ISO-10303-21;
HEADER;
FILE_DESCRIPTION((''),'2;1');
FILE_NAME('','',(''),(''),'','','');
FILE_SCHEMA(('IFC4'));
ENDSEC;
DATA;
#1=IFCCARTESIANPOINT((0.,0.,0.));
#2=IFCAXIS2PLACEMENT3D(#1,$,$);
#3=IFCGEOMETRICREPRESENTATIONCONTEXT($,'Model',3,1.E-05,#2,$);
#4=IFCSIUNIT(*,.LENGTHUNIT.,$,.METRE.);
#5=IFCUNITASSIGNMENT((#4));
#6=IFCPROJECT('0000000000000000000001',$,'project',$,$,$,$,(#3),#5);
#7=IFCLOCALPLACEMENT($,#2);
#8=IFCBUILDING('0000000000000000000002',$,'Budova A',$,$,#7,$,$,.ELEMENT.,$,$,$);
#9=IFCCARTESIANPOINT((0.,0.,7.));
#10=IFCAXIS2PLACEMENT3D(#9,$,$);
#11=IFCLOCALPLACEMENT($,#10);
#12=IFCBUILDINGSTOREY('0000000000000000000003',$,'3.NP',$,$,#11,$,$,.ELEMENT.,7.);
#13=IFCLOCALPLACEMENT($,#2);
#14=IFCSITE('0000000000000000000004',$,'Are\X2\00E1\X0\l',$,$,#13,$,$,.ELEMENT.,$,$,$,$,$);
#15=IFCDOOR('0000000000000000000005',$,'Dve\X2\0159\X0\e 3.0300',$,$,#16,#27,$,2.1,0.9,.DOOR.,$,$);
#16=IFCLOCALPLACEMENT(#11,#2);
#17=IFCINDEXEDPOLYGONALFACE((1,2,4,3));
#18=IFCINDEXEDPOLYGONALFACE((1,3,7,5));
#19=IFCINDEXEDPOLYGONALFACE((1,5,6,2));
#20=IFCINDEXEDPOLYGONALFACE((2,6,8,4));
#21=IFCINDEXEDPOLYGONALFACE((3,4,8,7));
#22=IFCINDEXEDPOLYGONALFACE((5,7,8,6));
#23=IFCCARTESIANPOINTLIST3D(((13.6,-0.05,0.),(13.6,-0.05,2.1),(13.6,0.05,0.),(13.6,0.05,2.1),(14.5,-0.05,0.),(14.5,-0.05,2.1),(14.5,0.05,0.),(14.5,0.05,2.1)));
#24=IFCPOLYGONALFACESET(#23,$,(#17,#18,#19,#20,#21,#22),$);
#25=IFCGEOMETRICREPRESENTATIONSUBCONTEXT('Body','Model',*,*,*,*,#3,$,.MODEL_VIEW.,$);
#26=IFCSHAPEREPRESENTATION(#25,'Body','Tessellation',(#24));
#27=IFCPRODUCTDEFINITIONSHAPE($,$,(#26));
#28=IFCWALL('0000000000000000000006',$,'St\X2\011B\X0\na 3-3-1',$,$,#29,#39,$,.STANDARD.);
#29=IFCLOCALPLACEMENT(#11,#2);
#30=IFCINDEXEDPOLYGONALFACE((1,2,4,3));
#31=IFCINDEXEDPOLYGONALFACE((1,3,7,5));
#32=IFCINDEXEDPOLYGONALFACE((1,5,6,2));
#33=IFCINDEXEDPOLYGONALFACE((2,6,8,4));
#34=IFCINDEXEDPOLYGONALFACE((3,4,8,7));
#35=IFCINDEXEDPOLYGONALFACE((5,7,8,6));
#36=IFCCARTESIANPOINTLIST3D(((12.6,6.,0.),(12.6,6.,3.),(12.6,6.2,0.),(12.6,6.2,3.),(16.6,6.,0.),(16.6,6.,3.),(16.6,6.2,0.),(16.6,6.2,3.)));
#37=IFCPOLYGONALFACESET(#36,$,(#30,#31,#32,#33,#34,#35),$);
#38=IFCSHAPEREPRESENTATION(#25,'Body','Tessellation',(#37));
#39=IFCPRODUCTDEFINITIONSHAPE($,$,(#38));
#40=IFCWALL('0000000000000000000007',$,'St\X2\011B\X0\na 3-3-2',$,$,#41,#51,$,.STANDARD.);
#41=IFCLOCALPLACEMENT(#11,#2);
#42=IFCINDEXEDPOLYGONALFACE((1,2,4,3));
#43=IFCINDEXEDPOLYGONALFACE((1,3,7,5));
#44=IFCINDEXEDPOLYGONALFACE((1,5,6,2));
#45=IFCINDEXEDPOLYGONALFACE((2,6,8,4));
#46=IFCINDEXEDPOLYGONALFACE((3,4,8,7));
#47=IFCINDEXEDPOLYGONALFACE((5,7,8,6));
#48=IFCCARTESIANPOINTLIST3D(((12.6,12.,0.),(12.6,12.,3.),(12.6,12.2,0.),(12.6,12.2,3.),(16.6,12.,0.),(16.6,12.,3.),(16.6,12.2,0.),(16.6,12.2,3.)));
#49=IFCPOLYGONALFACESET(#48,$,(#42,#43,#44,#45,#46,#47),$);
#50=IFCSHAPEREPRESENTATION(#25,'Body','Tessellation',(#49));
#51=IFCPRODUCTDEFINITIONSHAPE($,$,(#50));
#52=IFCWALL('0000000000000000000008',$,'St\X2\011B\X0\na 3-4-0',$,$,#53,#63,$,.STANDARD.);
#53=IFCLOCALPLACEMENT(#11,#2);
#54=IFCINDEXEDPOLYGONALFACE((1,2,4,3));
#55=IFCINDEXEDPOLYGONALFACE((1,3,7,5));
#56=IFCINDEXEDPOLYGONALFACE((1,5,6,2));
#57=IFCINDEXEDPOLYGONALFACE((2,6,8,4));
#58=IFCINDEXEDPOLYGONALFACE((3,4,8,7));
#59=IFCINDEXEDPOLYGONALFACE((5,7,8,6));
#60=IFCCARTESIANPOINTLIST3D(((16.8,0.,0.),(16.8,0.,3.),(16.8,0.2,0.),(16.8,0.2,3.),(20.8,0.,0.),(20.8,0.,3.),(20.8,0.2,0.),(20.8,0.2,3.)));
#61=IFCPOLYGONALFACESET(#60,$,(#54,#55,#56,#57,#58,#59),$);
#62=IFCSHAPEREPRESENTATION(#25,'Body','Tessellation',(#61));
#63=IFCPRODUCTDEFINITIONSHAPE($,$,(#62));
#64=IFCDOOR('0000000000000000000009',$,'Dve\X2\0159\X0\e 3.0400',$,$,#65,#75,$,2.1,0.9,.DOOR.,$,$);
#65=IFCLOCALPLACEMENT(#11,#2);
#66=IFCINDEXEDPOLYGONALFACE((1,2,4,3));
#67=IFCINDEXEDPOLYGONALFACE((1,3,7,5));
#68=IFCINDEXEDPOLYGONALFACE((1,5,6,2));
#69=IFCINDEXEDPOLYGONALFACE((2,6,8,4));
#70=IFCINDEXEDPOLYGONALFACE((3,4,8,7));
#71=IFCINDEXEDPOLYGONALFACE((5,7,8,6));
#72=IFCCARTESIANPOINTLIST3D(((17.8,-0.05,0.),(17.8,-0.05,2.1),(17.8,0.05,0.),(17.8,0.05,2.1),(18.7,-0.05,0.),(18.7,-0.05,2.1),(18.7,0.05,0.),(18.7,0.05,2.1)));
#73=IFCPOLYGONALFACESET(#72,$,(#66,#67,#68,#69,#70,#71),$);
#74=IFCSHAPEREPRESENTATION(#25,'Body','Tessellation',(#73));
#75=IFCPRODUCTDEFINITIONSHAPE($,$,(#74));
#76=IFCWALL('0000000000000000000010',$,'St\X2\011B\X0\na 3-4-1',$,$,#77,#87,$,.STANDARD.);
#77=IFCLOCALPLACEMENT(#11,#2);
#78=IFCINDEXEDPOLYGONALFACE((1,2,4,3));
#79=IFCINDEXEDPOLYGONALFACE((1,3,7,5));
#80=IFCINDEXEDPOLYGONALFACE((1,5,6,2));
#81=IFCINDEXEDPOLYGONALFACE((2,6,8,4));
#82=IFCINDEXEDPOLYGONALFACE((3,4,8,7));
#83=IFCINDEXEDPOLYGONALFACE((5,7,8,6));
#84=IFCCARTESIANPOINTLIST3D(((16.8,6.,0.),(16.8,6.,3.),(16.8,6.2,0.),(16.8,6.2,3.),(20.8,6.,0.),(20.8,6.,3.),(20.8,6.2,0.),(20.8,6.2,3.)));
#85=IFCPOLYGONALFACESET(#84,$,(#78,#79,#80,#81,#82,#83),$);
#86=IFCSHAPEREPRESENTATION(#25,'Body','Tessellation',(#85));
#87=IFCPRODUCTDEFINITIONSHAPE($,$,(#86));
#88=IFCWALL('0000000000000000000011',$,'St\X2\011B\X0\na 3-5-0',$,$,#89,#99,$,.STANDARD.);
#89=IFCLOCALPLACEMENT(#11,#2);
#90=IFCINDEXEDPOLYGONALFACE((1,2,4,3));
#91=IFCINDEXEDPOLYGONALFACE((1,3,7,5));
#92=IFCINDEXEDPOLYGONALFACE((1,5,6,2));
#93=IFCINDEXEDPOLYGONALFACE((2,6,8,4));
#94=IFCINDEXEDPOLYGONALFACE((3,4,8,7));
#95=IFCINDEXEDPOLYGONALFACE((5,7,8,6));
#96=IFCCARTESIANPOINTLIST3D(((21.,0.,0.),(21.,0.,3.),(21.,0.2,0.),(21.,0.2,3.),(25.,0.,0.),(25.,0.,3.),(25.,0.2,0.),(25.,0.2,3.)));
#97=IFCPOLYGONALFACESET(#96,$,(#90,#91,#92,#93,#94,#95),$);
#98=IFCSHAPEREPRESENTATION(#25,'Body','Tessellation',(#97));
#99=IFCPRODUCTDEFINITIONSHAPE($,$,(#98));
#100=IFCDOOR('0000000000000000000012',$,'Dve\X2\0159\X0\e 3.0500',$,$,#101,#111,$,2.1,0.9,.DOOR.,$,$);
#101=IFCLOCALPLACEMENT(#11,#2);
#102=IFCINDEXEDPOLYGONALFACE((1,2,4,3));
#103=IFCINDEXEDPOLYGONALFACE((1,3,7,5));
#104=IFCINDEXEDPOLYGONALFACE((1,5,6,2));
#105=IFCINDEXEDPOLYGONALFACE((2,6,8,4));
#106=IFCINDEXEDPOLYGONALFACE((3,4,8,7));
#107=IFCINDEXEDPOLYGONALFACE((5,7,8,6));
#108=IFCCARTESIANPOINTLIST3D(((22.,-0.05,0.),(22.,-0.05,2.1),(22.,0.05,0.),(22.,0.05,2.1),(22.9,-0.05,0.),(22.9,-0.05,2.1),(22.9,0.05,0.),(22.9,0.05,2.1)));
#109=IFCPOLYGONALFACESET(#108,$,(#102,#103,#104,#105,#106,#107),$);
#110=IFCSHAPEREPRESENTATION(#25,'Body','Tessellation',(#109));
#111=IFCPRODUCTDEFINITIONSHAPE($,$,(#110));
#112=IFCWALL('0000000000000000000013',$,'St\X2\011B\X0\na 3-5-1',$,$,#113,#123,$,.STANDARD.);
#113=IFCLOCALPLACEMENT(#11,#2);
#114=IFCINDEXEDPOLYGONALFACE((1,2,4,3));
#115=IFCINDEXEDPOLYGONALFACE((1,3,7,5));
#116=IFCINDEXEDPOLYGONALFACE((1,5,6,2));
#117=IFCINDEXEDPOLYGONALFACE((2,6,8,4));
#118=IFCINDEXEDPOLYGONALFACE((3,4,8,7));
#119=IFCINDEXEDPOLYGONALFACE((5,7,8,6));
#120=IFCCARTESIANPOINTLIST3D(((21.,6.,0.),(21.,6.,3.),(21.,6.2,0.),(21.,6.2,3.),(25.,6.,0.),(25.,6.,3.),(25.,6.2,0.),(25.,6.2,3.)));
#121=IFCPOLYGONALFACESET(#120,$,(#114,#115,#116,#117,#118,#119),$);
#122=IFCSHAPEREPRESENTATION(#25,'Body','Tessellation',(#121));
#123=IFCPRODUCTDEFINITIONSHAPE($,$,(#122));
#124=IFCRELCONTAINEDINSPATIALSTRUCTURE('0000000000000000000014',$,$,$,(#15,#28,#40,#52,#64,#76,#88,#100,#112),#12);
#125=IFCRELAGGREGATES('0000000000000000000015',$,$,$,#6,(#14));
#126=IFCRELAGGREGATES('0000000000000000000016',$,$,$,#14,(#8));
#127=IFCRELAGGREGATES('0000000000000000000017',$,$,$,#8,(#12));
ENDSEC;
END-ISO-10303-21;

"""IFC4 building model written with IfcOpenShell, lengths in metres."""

from ifc_helpers import new_model, si_unit, frame, frame_2d, origin, place, context, subcontext, project, spatial, rectangle, extrude, element, save


model = new_model("IFC4")

# Units and contexts
model_context = context("Model", 3, precision=1e-05, world=origin())
body_context = subcontext(model_context, "Body", "Model", "MODEL_VIEW")
ifc_project = project(units=[si_unit("LENGTHUNIT", "METRE")], contexts=[model_context])

# Site, building, storey
site_placement = place(None, origin())
site = spatial("IfcSite", under=ifc_project, at=site_placement, Name="Areál", CompositionType="ELEMENT")
building_placement = place(None, origin())
building = spatial("IfcBuilding", under=site, at=building_placement, Name="Budova A", CompositionType="ELEMENT")
storey_placement = place(None, frame((0.0, 0.0, 7.0)))
storey = spatial("IfcBuildingStorey", under=building, at=storey_placement, Name="3.NP", CompositionType="ELEMENT", Elevation=7.0)

# Door
door_1_placement = place(storey_placement, frame((13.6, -0.05, 0.0)))
element("IfcDoor", 1, at=door_1_placement, inside=storey, Name="Dveře 3.0300", OverallHeight=2.1, OverallWidth=0.9, PredefinedType="DOOR", context=body_context, shape_type="SweptSolid", body=[
    extrude(rectangle(XDim=0.9, YDim=0.1, at=frame_2d((0.45, 0.05))), origin(), (0.0, 0.0, 1.0), 2.1),
])

# Walls
for number, where, name in (
    (2, (12.6, 6.0, 0.0), "Stěna 3-3-1"),
    (3, (12.6, 12.0, 0.0), "Stěna 3-3-2"),
    (4, (16.8, 0.0, 0.0), "Stěna 3-4-0"),
):
    element("IfcWall", number, at=place(storey_placement, frame(where)), inside=storey, Name=name, PredefinedType="STANDARD", context=body_context, shape_type="SweptSolid", body=[
        extrude(rectangle(XDim=4.0, YDim=0.2, at=frame_2d((2.0, 0.1))), origin(), (0.0, 0.0, 1.0), 3.0),
    ])

# Door
door_2_placement = place(storey_placement, frame((17.8, -0.05, 0.0)))
element("IfcDoor", 5, at=door_2_placement, inside=storey, Name="Dveře 3.0400", OverallHeight=2.1, OverallWidth=0.9, PredefinedType="DOOR", context=body_context, shape_type="SweptSolid", body=[
    extrude(rectangle(XDim=0.9, YDim=0.1, at=frame_2d((0.45, 0.05))), origin(), (0.0, 0.0, 1.0), 2.1),
])

# Walls
for number, where, name in (
    (6, (16.8, 6.0, 0.0), "Stěna 3-4-1"),
    (7, (21.0, 0.0, 0.0), "Stěna 3-5-0"),
):
    element("IfcWall", number, at=place(storey_placement, frame(where)), inside=storey, Name=name, PredefinedType="STANDARD", context=body_context, shape_type="SweptSolid", body=[
        extrude(rectangle(XDim=4.0, YDim=0.2, at=frame_2d((2.0, 0.1))), origin(), (0.0, 0.0, 1.0), 3.0),
    ])

# Door
door_3_placement = place(storey_placement, frame((22.0, -0.05, 0.0)))
element("IfcDoor", 8, at=door_3_placement, inside=storey, Name="Dveře 3.0500", OverallHeight=2.1, OverallWidth=0.9, PredefinedType="DOOR", context=body_context, shape_type="SweptSolid", body=[
    extrude(rectangle(XDim=0.9, YDim=0.1, at=frame_2d((0.45, 0.05))), origin(), (0.0, 0.0, 1.0), 2.1),
])

# Wall
wall_1_placement = place(storey_placement, frame((21.0, 6.0, 0.0)))
element("IfcWall", 9, at=wall_1_placement, inside=storey, Name="Stěna 3-5-1", PredefinedType="STANDARD", context=body_context, shape_type="SweptSolid", body=[
    extrude(rectangle(XDim=4.0, YDim=0.2, at=frame_2d((2.0, 0.1))), origin(), (0.0, 0.0, 1.0), 3.0),
])

save(model, "model.ifc")
